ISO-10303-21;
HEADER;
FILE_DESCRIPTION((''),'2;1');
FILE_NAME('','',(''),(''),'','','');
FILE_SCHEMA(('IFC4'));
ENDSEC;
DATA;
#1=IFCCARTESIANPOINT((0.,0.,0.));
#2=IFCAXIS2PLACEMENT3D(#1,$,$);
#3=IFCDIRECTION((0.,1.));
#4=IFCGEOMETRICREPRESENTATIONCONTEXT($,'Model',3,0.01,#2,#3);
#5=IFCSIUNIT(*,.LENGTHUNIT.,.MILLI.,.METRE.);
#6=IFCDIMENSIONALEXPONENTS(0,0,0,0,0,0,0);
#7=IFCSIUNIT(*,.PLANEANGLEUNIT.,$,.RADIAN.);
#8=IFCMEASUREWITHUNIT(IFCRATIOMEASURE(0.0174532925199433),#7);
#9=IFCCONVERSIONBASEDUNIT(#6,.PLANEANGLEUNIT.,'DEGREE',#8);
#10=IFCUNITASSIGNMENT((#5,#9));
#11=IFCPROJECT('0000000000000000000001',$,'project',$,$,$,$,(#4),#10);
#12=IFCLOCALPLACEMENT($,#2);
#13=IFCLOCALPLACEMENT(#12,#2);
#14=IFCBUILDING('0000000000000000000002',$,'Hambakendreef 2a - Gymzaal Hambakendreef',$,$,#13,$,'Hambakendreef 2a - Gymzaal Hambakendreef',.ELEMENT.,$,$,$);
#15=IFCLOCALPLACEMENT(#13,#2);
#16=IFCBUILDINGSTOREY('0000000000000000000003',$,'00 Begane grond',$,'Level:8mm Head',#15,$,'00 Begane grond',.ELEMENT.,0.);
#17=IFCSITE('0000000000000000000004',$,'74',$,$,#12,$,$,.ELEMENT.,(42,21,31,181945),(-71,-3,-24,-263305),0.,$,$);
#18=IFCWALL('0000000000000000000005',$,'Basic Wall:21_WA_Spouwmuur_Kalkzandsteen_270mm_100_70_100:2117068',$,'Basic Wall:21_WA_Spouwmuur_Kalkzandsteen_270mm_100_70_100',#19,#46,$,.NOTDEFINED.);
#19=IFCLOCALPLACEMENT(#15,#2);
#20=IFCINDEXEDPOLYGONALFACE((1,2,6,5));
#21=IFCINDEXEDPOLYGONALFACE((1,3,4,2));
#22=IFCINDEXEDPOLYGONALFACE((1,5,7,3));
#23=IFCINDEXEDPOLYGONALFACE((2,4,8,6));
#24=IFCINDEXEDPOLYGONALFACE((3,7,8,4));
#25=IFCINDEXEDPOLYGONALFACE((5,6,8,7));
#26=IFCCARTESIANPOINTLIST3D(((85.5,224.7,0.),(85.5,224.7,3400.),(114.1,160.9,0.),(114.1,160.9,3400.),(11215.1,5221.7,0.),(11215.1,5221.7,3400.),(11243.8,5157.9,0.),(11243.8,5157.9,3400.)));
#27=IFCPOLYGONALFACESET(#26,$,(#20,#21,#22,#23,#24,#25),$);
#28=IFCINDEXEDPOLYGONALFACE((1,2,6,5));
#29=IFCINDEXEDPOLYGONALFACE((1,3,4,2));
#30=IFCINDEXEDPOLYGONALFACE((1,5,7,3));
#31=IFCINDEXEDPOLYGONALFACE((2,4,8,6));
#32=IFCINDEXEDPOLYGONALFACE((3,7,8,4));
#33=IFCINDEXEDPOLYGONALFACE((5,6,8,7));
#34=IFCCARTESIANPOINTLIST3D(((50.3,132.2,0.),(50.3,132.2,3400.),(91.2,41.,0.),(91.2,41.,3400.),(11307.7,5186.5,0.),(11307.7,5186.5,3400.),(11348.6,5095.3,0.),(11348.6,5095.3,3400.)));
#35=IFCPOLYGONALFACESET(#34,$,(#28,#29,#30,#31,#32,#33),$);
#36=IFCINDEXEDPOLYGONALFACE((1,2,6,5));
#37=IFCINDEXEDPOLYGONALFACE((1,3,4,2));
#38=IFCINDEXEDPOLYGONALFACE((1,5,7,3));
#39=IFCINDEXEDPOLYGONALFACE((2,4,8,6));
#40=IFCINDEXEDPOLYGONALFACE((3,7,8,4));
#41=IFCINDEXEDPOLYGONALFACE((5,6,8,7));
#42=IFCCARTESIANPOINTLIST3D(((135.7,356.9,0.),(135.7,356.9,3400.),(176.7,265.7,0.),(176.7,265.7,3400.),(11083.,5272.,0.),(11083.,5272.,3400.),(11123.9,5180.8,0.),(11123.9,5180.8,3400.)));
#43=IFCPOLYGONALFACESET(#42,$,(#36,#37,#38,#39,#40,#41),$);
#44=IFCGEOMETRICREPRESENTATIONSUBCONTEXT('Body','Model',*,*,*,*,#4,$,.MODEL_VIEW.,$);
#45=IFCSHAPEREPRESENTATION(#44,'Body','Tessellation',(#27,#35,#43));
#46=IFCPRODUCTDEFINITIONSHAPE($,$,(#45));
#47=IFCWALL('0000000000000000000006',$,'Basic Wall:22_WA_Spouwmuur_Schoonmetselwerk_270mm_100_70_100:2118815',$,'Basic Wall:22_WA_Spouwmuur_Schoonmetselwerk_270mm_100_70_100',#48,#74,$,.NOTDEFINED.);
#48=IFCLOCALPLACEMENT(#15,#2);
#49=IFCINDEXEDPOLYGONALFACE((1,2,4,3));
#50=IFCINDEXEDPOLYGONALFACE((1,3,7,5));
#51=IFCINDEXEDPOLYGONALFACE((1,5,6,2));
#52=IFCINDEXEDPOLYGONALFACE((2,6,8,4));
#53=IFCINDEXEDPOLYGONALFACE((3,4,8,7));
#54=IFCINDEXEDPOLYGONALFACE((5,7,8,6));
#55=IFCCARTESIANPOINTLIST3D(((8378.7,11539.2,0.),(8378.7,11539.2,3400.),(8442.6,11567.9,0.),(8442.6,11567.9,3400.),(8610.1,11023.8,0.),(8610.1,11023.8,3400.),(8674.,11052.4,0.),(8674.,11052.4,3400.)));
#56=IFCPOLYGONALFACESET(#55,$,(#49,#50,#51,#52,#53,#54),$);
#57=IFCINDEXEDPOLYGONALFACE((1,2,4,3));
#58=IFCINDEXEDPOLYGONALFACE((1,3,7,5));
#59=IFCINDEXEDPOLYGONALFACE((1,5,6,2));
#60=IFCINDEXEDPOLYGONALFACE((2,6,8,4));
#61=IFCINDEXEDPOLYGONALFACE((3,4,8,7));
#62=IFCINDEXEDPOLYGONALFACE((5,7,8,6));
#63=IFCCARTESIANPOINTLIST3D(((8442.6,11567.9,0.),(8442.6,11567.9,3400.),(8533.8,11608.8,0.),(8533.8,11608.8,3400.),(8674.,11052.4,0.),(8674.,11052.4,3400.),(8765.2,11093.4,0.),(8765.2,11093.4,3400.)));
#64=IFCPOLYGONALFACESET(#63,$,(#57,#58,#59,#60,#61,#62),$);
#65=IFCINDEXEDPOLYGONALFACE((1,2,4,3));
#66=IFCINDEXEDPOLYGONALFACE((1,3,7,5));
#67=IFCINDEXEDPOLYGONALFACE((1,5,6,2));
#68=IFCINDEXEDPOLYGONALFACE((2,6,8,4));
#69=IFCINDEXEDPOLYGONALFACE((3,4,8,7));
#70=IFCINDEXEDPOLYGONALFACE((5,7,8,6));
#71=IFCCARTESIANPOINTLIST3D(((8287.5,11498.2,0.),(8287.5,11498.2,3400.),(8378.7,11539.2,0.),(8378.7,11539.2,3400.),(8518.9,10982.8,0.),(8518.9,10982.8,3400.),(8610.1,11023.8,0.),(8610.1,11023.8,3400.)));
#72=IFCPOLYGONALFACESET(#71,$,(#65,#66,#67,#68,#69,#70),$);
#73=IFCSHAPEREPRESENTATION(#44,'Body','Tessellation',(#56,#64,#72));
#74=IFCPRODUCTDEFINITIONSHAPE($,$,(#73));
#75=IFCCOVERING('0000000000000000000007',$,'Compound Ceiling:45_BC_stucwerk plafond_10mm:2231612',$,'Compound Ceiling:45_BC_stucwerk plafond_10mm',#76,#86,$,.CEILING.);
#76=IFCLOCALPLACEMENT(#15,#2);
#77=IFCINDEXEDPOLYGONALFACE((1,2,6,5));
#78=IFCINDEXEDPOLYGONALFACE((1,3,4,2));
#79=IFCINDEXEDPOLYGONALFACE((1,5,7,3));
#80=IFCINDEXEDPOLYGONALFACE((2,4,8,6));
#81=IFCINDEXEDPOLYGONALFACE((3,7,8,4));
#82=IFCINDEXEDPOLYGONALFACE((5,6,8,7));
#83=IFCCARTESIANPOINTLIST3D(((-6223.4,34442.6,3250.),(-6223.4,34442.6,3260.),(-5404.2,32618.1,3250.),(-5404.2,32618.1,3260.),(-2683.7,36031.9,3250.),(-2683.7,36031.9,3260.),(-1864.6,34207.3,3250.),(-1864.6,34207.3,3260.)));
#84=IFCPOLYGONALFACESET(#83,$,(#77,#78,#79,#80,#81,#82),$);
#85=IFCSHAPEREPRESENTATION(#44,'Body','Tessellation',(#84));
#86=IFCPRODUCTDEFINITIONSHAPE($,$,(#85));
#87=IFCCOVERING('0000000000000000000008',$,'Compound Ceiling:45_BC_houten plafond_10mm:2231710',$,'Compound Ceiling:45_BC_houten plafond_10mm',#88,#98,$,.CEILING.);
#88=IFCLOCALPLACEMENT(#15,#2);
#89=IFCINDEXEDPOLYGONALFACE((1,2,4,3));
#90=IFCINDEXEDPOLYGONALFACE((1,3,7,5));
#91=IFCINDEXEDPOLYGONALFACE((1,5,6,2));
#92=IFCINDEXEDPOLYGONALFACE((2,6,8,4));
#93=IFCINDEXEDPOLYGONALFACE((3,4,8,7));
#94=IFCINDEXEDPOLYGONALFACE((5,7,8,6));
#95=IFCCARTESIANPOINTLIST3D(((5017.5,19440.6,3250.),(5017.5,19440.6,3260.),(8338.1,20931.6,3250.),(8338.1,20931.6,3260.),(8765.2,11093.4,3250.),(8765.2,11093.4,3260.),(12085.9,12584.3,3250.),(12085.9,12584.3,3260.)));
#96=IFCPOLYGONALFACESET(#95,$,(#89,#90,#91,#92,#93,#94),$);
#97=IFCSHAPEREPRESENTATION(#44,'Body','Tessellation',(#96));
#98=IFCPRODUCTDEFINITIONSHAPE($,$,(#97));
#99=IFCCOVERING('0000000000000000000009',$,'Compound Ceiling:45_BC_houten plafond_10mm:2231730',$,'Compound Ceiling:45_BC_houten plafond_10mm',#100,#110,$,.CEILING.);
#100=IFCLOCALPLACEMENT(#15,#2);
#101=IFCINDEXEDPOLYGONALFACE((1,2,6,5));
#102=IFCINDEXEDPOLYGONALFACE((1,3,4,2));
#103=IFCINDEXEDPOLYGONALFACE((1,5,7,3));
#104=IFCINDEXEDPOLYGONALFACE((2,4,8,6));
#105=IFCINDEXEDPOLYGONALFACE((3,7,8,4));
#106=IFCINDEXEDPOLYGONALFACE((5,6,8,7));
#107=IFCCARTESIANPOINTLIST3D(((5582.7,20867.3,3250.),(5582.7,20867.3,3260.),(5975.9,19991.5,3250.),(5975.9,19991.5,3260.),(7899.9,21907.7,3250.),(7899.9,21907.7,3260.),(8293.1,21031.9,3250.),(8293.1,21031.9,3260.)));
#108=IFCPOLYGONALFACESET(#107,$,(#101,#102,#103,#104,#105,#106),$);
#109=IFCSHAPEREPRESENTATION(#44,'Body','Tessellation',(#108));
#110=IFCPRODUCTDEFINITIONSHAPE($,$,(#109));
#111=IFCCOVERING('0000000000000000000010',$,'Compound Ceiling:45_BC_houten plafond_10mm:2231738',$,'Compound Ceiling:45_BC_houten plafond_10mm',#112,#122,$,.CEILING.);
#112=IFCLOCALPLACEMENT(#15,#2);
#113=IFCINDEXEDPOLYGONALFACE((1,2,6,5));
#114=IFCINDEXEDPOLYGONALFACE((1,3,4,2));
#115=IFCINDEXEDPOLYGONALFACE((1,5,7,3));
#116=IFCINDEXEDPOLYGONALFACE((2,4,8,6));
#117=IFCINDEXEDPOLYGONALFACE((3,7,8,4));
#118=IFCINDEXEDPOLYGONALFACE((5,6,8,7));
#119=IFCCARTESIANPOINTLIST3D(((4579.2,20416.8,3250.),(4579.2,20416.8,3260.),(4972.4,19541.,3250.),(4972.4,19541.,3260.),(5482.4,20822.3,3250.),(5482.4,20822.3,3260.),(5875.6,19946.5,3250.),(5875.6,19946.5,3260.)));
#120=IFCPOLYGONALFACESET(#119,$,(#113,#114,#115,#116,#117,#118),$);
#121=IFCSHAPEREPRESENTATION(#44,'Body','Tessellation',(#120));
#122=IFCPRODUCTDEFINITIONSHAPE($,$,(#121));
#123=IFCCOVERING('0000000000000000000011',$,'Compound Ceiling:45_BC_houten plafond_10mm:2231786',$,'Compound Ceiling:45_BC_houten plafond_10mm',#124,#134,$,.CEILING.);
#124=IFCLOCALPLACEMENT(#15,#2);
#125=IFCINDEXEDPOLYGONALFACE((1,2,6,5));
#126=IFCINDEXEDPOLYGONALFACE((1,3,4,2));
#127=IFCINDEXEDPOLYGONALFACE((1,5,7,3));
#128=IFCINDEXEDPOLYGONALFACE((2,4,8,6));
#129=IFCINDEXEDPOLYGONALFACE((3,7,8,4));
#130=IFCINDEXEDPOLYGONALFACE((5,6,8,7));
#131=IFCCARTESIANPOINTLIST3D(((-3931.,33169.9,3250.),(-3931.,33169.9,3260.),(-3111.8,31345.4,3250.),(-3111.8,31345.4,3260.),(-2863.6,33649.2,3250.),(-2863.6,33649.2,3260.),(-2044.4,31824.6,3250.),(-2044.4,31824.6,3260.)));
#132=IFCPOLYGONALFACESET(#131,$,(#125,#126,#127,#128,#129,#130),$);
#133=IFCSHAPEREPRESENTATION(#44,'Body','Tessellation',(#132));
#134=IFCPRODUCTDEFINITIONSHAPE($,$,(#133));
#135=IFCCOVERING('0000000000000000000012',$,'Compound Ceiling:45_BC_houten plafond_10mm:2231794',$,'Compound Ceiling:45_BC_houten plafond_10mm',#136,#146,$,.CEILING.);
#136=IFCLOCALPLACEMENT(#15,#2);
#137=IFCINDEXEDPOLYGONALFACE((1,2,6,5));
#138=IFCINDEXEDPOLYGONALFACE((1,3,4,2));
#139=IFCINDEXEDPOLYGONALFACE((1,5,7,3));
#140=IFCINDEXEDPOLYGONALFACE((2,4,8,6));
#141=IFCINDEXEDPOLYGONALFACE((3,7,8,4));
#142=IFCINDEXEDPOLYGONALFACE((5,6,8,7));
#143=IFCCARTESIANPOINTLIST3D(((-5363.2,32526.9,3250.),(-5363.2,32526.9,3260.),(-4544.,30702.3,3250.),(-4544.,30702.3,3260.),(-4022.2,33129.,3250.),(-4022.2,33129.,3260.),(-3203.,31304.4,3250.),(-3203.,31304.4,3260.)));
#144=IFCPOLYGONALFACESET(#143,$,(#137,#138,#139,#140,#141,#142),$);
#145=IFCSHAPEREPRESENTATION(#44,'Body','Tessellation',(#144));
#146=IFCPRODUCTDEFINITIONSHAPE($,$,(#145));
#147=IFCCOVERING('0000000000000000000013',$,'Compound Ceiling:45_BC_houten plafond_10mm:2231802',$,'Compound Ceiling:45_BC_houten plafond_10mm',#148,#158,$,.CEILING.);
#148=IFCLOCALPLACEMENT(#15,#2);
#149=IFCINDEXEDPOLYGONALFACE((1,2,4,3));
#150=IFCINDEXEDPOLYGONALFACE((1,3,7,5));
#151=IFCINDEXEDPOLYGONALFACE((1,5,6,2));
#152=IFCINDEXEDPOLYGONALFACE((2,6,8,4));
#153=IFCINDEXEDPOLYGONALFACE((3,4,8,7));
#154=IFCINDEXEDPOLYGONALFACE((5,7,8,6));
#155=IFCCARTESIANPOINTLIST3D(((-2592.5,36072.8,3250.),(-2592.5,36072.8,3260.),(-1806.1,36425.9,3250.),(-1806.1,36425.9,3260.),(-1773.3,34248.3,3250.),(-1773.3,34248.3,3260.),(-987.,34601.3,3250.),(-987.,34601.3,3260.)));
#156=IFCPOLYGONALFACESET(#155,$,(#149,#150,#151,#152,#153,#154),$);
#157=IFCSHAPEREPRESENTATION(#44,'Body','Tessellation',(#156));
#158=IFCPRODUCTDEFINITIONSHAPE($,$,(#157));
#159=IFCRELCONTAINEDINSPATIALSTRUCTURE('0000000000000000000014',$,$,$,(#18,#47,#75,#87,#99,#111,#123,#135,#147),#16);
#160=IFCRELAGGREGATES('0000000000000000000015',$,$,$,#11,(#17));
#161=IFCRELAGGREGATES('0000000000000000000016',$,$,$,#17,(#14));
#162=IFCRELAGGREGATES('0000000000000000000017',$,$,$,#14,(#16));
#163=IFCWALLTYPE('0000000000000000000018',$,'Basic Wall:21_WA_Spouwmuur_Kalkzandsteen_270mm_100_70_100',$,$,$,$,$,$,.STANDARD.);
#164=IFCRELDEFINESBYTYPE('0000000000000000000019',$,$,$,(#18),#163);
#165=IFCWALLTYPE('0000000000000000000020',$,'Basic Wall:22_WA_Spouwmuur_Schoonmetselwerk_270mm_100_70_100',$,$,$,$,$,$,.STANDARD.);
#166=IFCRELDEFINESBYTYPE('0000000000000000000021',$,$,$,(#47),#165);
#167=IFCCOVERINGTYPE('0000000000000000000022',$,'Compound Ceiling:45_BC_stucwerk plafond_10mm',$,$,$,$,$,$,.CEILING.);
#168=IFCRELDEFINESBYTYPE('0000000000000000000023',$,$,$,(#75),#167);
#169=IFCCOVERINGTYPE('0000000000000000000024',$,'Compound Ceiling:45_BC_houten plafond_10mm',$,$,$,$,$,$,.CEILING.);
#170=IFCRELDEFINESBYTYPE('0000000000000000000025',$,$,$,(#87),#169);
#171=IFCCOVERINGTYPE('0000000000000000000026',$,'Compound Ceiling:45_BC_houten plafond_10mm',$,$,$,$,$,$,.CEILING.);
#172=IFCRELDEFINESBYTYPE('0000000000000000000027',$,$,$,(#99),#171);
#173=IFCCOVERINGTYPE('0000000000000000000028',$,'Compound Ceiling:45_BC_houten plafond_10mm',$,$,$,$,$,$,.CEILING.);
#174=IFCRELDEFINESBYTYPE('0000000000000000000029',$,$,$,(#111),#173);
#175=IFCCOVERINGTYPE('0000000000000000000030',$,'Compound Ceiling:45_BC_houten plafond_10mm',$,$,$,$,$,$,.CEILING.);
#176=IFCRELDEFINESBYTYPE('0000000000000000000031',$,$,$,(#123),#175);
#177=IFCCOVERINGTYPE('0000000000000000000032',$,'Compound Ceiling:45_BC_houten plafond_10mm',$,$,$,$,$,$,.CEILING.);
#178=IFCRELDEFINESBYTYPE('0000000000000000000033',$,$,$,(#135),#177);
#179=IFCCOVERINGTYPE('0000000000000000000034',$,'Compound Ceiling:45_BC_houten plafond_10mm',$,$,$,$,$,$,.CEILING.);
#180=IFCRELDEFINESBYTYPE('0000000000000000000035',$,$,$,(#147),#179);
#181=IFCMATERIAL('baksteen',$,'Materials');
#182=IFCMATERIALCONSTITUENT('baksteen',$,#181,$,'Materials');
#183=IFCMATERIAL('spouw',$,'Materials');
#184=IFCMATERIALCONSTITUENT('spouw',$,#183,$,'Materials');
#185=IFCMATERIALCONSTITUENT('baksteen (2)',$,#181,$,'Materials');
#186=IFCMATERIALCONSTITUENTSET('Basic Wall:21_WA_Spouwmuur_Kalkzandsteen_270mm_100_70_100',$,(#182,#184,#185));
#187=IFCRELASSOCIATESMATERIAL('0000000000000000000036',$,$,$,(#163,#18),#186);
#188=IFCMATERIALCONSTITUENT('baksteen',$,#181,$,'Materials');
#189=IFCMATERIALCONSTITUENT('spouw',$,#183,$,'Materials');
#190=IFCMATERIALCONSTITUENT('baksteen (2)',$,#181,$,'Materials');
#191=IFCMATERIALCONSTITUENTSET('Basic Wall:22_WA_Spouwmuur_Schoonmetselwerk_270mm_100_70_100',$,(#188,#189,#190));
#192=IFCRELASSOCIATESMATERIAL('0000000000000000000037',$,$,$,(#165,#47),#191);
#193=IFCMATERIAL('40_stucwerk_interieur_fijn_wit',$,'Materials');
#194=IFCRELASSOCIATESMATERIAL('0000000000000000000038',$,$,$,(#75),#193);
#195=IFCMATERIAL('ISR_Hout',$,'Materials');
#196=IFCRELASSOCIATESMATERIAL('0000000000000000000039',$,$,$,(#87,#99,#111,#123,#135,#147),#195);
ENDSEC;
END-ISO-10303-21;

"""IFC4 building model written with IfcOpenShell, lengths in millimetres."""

from ifc_helpers import new_model, entity, si_unit, converted_unit, direction, frame, origin, place, context, subcontext, project, spatial, indexed_curve, outline, extrude, material, constituent, constituent_set, type_object, element, save


model = new_model("IFC4")

# Units and contexts
model_context = context("Model", 3, precision=0.01, world=origin(), true_north=direction((0.0, 1.0)))
body_context = subcontext(model_context, "Body", "Model", "MODEL_VIEW")
ifc_project = project(units=[si_unit("LENGTHUNIT", "METRE", prefix="MILLI"), converted_unit("PLANEANGLEUNIT", "DEGREE", entity("IfcRatioMeasure", 0.0174532925199433), si_unit("PLANEANGLEUNIT", "RADIAN"), dimensions=[0, 0, 0, 0, 0, 0, 0])], contexts=[model_context])

# Site, building, storey
site_placement = place(None, origin())
site = spatial("IfcSite", under=ifc_project, at=site_placement, Name="74", CompositionType="ELEMENT", RefLatitude=(42, 21, 31, 181945), RefLongitude=(-71, -3, -24, -263305), RefElevation=0.0)
building_placement = place(site_placement, origin())
building = spatial("IfcBuilding", under=site, at=building_placement, Name="Hambakendreef 2a - Gymzaal Hambakendreef", LongName="Hambakendreef 2a - Gymzaal Hambakendreef", CompositionType="ELEMENT")
storey_placement = place(building_placement, origin())
storey = spatial("IfcBuildingStorey", under=building, at=storey_placement, Name="00 Begane grond", ObjectType="Level:8mm Head", LongName="00 Begane grond", CompositionType="ELEMENT", Elevation=0.0)

# Shared definitions
ifc_material_1 = material(Name="baksteen", Category="Materials")
ifc_constituent_1 = constituent(ifc_material_1, Name="baksteen", Category="Materials")
ifc_material_2 = material(Name="spouw", Category="Materials")
ifc_constituent_2 = constituent(ifc_material_2, Name="spouw", Category="Materials")
ifc_constituent_3 = constituent(ifc_material_1, Name="baksteen (2)", Category="Materials")
ifc_constituent_set_1 = constituent_set(constituents=[ifc_constituent_1, ifc_constituent_2, ifc_constituent_3], Name="Basic Wall:21_WA_Spouwmuur_Kalkzandsteen_270mm_100_70_100")
wall_type_1 = type_object("IfcWallType", Name="Basic Wall:21_WA_Spouwmuur_Kalkzandsteen_270mm_100_70_100", PredefinedType="STANDARD", material=ifc_constituent_set_1)

# Wall
wall_1_placement = place(storey_placement, frame((11138.3, 5148.8, 0.0), z_axis=(0.0, 0.0, 1.0), x_axis=(-0.91227, -0.40959, 0.0)))
element("IfcWall", 1, at=wall_1_placement, inside=storey, type_object=wall_type_1, material=ifc_constituent_set_1, Name="Basic Wall:21_WA_Spouwmuur_Kalkzandsteen_270mm_100_70_100:2117068", ObjectType="Basic Wall:21_WA_Spouwmuur_Kalkzandsteen_270mm_100_70_100", PredefinedType="NOTDEFINED", context=body_context, shape_type="SweptSolid", body=[
    extrude(outline(indexed_curve([(-6100.0, -35.0), (6100.0, -35.0), (6100.0, 35.0), (-6100.0, 35.0), (-6100.0, -35.0)], self_intersect=False)), frame((6000.0, 0.0, 0.0)), (0.0, 0.0, 1.0), 3400.0),
    extrude(outline(indexed_curve([(-50.0, -6170.0), (50.0, -6170.0), (50.0, 6170.0), (-50.0, 6170.0), (-50.0, -6170.0)], self_intersect=False)), frame((6000.0, 85.0, 0.0), z_axis=(0.0, 0.0, 1.0), x_axis=(0.0, -1.0, 0.0)), (0.0, 0.0, 1.0), 3400.0),
    extrude(outline(indexed_curve([(-50.0, -6000.0), (50.0, -6000.0), (50.0, 6000.0), (-50.0, 6000.0), (-50.0, -6000.0)], self_intersect=False)), frame((6000.0, -85.0, 0.0), z_axis=(0.0, 0.0, 1.0), x_axis=(0.0, 1.0, 0.0)), (0.0, 0.0, 1.0), 3400.0),
])

# Wall, opening
ifc_constituent_4 = constituent(ifc_material_1, Name="baksteen", Category="Materials")
ifc_constituent_5 = constituent(ifc_material_2, Name="spouw", Category="Materials")
ifc_constituent_6 = constituent(ifc_material_1, Name="baksteen (2)", Category="Materials")
ifc_constituent_set_2 = constituent_set(constituents=[ifc_constituent_4, ifc_constituent_5, ifc_constituent_6], Name="Basic Wall:22_WA_Spouwmuur_Schoonmetselwerk_270mm_100_70_100")
wall_type_2 = type_object("IfcWallType", Name="Basic Wall:22_WA_Spouwmuur_Schoonmetselwerk_270mm_100_70_100", PredefinedType="STANDARD", material=ifc_constituent_set_2)
wall_2_placement = place(storey_placement, frame((8410.7, 11553.5, 0.0), z_axis=(0.0, 0.0, 1.0), x_axis=(0.40959, -0.91227, 0.0)))
wall_2 = element("IfcWall", 2, at=wall_2_placement, inside=storey, type_object=wall_type_2, material=ifc_constituent_set_2, Name="Basic Wall:22_WA_Spouwmuur_Schoonmetselwerk_270mm_100_70_100:2118815", ObjectType="Basic Wall:22_WA_Spouwmuur_Schoonmetselwerk_270mm_100_70_100", PredefinedType="NOTDEFINED", context=body_context, shape_type="SweptSolid", body=[
    extrude(outline(indexed_curve([(-282.5, -35.0), (282.5, -35.0), (282.5, 35.0), (-282.5, 35.0), (-282.5, -35.0)], self_intersect=False)), frame((282.5, 0.0, 0.0)), (0.0, 0.0, 1.0), 3400.0),
    extrude(outline(indexed_curve([(-50.0, -282.5), (50.0, -282.5), (50.0, 282.5), (-50.0, 282.5), (-50.0, -282.5)], self_intersect=False)), frame((282.5, 85.0, 0.0), z_axis=(0.0, 0.0, 1.0), x_axis=(0.0, -1.0, 0.0)), (0.0, 0.0, 1.0), 3400.0),
    extrude(outline(indexed_curve([(-50.0, -282.5), (50.0, -282.5), (50.0, 282.5), (-50.0, 282.5), (-50.0, -282.5)], self_intersect=False)), frame((282.5, -85.0, 0.0), z_axis=(0.0, 0.0, 1.0), x_axis=(0.0, 1.0, 0.0)), (0.0, 0.0, 1.0), 3400.0),
])
opening_1_placement = place(wall_2_placement, origin())
element("IfcOpeningElement", 3, at=opening_1_placement, cuts=wall_2, PredefinedType="OPENING", context=body_context, shape_type="SweptSolid", body=[
    extrude(outline(indexed_curve([(-1050.0, -457.5), (1050.0, -457.5), (1050.0, 457.5), (-1050.0, 457.5), (-1050.0, -457.5)], self_intersect=False)), frame((-13257.5, -287.4, 1050.0), z_axis=(0.0, 1.0, 0.0), x_axis=(0.0, 0.0, 1.0)), (0.0, 0.0, 1.0), 574.8),
])

# Coverings
ifc_material_3 = material(Name="ISR_Hout", Category="Materials")
ifc_material_4 = material(Name="40_stucwerk_interieur_fijn_wit", Category="Materials")
covering_type_1 = type_object("IfcCoveringType", Name="Compound Ceiling:45_BC_stucwerk plafond_10mm", PredefinedType="CEILING")
covering_1_placement = place(storey_placement, origin())
element("IfcCovering", 4, at=covering_1_placement, inside=storey, type_object=covering_type_1, material=ifc_material_4, Name="Compound Ceiling:45_BC_stucwerk plafond_10mm:2231612", ObjectType="Compound Ceiling:45_BC_stucwerk plafond_10mm", PredefinedType="CEILING", context=body_context, shape_type="SweptSolid", body=[
    extrude(outline(indexed_curve([(-1940.0, -1000.0), (1940.0, -1000.0), (1940.0, 1000.0), (-1940.0, 1000.0), (-1940.0, -1000.0)], self_intersect=False)), frame((-4044.0, 34325.0, 3250.0), z_axis=(0.0, 0.0, 1.0), x_axis=(0.91227, 0.40959, 0.0)), (0.0, 0.0, 1.0), 10.0),
])
covering_type_2 = type_object("IfcCoveringType", Name="Compound Ceiling:45_BC_houten plafond_10mm", PredefinedType="CEILING")
covering_2_placement = place(storey_placement, origin())
element("IfcCovering", 5, at=covering_2_placement, inside=storey, type_object=covering_type_2, material=ifc_material_3, Name="Compound Ceiling:45_BC_houten plafond_10mm:2231710", ObjectType="Compound Ceiling:45_BC_houten plafond_10mm", PredefinedType="CEILING", context=body_context, shape_type="SweptSolid", body=[
    extrude(outline(indexed_curve([(-1820.0, -4575.0), (1820.0, -4575.0), (1820.0, 4575.0), (-1820.0, 4575.0), (-1820.0, -4575.0)], self_intersect=False)), frame((8551.7, 16012.5, 3250.0), z_axis=(0.0, 0.0, 1.0), x_axis=(0.91227, 0.40959, 0.0)), (0.0, 0.0, 1.0), 10.0),
])
covering_type_3 = type_object("IfcCoveringType", Name="Compound Ceiling:45_BC_houten plafond_10mm", PredefinedType="CEILING")
covering_3_placement = place(storey_placement, origin())
element("IfcCovering", 6, at=covering_3_placement, inside=storey, type_object=covering_type_3, material=ifc_material_3, Name="Compound Ceiling:45_BC_houten plafond_10mm:2231730", ObjectType="Compound Ceiling:45_BC_houten plafond_10mm", PredefinedType="CEILING", context=body_context, shape_type="SweptSolid", body=[
    extrude(outline(indexed_curve([(-480.0, -1270.0), (480.0, -1270.0), (480.0, 1270.0), (-480.0, 1270.0), (-480.0, -1270.0)], self_intersect=False)), frame((6937.9, 20949.6, 3250.0), z_axis=(0.0, 0.0, 1.0), x_axis=(0.40959, -0.91227, 0.0)), (0.0, 0.0, 1.0), 10.0),
])
covering_type_4 = type_object("IfcCoveringType", Name="Compound Ceiling:45_BC_houten plafond_10mm", PredefinedType="CEILING")
covering_4_placement = place(storey_placement, origin())
element("IfcCovering", 7, at=covering_4_placement, inside=storey, type_object=covering_type_4, material=ifc_material_3, Name="Compound Ceiling:45_BC_houten plafond_10mm:2231738", ObjectType="Compound Ceiling:45_BC_houten plafond_10mm", PredefinedType="CEILING", context=body_context, shape_type="SweptSolid", body=[
    extrude(outline(indexed_curve([(-495.0, -480.0), (495.0, -480.0), (495.0, 480.0), (-495.0, 480.0), (-495.0, -480.0)], self_intersect=False)), frame((5227.4, 20181.6, 3250.0), z_axis=(0.0, 0.0, 1.0), x_axis=(0.91227, 0.40959, 0.0)), (0.0, 0.0, 1.0), 10.0),
])
covering_type_5 = type_object("IfcCoveringType", Name="Compound Ceiling:45_BC_houten plafond_10mm", PredefinedType="CEILING")
covering_5_placement = place(storey_placement, origin())
element("IfcCovering", 8, at=covering_5_placement, inside=storey, type_object=covering_type_5, material=ifc_material_3, Name="Compound Ceiling:45_BC_houten plafond_10mm:2231786", ObjectType="Compound Ceiling:45_BC_houten plafond_10mm", PredefinedType="CEILING", context=body_context, shape_type="SweptSolid", body=[
    extrude(outline(indexed_curve([(-585.0, -1000.0), (585.0, -1000.0), (585.0, 1000.0), (-585.0, 1000.0), (-585.0, -1000.0)], self_intersect=False)), frame((-2987.7, 32497.3, 3250.0), z_axis=(0.0, 0.0, 1.0), x_axis=(0.91227, 0.40959, 0.0)), (0.0, 0.0, 1.0), 10.0),
])
covering_type_6 = type_object("IfcCoveringType", Name="Compound Ceiling:45_BC_houten plafond_10mm", PredefinedType="CEILING")
covering_6_placement = place(storey_placement, origin())
element("IfcCovering", 9, at=covering_6_placement, inside=storey, type_object=covering_type_6, material=ifc_material_3, Name="Compound Ceiling:45_BC_houten plafond_10mm:2231794", ObjectType="Compound Ceiling:45_BC_houten plafond_10mm", PredefinedType="CEILING", context=body_context, shape_type="SweptSolid", body=[
    extrude(outline(indexed_curve([(-1000.0, -735.0), (1000.0, -735.0), (1000.0, 735.0), (-1000.0, 735.0), (-1000.0, -735.0)], self_intersect=False)), frame((-4283.1, 31915.7, 3250.0), z_axis=(0.0, 0.0, 1.0), x_axis=(-0.40959, 0.91227, 0.0)), (0.0, 0.0, 1.0), 10.0),
])
covering_type_7 = type_object("IfcCoveringType", Name="Compound Ceiling:45_BC_houten plafond_10mm", PredefinedType="CEILING")
covering_7_placement = place(storey_placement, origin())
element("IfcCovering", 10, at=covering_7_placement, inside=storey, type_object=covering_type_7, material=ifc_material_3, Name="Compound Ceiling:45_BC_houten plafond_10mm:2231802", ObjectType="Compound Ceiling:45_BC_houten plafond_10mm", PredefinedType="CEILING", context=body_context, shape_type="SweptSolid", body=[
    extrude(outline(indexed_curve([(-431.0, -1000.0), (431.0, -1000.0), (431.0, 1000.0), (-431.0, 1000.0), (-431.0, -1000.0)], self_intersect=False)), frame((-1789.7, 35337.1, 3250.0), z_axis=(0.0, 0.0, 1.0), x_axis=(0.91227, 0.40959, 0.0)), (0.0, 0.0, 1.0), 10.0),
])

save(model, "model.ifc")
